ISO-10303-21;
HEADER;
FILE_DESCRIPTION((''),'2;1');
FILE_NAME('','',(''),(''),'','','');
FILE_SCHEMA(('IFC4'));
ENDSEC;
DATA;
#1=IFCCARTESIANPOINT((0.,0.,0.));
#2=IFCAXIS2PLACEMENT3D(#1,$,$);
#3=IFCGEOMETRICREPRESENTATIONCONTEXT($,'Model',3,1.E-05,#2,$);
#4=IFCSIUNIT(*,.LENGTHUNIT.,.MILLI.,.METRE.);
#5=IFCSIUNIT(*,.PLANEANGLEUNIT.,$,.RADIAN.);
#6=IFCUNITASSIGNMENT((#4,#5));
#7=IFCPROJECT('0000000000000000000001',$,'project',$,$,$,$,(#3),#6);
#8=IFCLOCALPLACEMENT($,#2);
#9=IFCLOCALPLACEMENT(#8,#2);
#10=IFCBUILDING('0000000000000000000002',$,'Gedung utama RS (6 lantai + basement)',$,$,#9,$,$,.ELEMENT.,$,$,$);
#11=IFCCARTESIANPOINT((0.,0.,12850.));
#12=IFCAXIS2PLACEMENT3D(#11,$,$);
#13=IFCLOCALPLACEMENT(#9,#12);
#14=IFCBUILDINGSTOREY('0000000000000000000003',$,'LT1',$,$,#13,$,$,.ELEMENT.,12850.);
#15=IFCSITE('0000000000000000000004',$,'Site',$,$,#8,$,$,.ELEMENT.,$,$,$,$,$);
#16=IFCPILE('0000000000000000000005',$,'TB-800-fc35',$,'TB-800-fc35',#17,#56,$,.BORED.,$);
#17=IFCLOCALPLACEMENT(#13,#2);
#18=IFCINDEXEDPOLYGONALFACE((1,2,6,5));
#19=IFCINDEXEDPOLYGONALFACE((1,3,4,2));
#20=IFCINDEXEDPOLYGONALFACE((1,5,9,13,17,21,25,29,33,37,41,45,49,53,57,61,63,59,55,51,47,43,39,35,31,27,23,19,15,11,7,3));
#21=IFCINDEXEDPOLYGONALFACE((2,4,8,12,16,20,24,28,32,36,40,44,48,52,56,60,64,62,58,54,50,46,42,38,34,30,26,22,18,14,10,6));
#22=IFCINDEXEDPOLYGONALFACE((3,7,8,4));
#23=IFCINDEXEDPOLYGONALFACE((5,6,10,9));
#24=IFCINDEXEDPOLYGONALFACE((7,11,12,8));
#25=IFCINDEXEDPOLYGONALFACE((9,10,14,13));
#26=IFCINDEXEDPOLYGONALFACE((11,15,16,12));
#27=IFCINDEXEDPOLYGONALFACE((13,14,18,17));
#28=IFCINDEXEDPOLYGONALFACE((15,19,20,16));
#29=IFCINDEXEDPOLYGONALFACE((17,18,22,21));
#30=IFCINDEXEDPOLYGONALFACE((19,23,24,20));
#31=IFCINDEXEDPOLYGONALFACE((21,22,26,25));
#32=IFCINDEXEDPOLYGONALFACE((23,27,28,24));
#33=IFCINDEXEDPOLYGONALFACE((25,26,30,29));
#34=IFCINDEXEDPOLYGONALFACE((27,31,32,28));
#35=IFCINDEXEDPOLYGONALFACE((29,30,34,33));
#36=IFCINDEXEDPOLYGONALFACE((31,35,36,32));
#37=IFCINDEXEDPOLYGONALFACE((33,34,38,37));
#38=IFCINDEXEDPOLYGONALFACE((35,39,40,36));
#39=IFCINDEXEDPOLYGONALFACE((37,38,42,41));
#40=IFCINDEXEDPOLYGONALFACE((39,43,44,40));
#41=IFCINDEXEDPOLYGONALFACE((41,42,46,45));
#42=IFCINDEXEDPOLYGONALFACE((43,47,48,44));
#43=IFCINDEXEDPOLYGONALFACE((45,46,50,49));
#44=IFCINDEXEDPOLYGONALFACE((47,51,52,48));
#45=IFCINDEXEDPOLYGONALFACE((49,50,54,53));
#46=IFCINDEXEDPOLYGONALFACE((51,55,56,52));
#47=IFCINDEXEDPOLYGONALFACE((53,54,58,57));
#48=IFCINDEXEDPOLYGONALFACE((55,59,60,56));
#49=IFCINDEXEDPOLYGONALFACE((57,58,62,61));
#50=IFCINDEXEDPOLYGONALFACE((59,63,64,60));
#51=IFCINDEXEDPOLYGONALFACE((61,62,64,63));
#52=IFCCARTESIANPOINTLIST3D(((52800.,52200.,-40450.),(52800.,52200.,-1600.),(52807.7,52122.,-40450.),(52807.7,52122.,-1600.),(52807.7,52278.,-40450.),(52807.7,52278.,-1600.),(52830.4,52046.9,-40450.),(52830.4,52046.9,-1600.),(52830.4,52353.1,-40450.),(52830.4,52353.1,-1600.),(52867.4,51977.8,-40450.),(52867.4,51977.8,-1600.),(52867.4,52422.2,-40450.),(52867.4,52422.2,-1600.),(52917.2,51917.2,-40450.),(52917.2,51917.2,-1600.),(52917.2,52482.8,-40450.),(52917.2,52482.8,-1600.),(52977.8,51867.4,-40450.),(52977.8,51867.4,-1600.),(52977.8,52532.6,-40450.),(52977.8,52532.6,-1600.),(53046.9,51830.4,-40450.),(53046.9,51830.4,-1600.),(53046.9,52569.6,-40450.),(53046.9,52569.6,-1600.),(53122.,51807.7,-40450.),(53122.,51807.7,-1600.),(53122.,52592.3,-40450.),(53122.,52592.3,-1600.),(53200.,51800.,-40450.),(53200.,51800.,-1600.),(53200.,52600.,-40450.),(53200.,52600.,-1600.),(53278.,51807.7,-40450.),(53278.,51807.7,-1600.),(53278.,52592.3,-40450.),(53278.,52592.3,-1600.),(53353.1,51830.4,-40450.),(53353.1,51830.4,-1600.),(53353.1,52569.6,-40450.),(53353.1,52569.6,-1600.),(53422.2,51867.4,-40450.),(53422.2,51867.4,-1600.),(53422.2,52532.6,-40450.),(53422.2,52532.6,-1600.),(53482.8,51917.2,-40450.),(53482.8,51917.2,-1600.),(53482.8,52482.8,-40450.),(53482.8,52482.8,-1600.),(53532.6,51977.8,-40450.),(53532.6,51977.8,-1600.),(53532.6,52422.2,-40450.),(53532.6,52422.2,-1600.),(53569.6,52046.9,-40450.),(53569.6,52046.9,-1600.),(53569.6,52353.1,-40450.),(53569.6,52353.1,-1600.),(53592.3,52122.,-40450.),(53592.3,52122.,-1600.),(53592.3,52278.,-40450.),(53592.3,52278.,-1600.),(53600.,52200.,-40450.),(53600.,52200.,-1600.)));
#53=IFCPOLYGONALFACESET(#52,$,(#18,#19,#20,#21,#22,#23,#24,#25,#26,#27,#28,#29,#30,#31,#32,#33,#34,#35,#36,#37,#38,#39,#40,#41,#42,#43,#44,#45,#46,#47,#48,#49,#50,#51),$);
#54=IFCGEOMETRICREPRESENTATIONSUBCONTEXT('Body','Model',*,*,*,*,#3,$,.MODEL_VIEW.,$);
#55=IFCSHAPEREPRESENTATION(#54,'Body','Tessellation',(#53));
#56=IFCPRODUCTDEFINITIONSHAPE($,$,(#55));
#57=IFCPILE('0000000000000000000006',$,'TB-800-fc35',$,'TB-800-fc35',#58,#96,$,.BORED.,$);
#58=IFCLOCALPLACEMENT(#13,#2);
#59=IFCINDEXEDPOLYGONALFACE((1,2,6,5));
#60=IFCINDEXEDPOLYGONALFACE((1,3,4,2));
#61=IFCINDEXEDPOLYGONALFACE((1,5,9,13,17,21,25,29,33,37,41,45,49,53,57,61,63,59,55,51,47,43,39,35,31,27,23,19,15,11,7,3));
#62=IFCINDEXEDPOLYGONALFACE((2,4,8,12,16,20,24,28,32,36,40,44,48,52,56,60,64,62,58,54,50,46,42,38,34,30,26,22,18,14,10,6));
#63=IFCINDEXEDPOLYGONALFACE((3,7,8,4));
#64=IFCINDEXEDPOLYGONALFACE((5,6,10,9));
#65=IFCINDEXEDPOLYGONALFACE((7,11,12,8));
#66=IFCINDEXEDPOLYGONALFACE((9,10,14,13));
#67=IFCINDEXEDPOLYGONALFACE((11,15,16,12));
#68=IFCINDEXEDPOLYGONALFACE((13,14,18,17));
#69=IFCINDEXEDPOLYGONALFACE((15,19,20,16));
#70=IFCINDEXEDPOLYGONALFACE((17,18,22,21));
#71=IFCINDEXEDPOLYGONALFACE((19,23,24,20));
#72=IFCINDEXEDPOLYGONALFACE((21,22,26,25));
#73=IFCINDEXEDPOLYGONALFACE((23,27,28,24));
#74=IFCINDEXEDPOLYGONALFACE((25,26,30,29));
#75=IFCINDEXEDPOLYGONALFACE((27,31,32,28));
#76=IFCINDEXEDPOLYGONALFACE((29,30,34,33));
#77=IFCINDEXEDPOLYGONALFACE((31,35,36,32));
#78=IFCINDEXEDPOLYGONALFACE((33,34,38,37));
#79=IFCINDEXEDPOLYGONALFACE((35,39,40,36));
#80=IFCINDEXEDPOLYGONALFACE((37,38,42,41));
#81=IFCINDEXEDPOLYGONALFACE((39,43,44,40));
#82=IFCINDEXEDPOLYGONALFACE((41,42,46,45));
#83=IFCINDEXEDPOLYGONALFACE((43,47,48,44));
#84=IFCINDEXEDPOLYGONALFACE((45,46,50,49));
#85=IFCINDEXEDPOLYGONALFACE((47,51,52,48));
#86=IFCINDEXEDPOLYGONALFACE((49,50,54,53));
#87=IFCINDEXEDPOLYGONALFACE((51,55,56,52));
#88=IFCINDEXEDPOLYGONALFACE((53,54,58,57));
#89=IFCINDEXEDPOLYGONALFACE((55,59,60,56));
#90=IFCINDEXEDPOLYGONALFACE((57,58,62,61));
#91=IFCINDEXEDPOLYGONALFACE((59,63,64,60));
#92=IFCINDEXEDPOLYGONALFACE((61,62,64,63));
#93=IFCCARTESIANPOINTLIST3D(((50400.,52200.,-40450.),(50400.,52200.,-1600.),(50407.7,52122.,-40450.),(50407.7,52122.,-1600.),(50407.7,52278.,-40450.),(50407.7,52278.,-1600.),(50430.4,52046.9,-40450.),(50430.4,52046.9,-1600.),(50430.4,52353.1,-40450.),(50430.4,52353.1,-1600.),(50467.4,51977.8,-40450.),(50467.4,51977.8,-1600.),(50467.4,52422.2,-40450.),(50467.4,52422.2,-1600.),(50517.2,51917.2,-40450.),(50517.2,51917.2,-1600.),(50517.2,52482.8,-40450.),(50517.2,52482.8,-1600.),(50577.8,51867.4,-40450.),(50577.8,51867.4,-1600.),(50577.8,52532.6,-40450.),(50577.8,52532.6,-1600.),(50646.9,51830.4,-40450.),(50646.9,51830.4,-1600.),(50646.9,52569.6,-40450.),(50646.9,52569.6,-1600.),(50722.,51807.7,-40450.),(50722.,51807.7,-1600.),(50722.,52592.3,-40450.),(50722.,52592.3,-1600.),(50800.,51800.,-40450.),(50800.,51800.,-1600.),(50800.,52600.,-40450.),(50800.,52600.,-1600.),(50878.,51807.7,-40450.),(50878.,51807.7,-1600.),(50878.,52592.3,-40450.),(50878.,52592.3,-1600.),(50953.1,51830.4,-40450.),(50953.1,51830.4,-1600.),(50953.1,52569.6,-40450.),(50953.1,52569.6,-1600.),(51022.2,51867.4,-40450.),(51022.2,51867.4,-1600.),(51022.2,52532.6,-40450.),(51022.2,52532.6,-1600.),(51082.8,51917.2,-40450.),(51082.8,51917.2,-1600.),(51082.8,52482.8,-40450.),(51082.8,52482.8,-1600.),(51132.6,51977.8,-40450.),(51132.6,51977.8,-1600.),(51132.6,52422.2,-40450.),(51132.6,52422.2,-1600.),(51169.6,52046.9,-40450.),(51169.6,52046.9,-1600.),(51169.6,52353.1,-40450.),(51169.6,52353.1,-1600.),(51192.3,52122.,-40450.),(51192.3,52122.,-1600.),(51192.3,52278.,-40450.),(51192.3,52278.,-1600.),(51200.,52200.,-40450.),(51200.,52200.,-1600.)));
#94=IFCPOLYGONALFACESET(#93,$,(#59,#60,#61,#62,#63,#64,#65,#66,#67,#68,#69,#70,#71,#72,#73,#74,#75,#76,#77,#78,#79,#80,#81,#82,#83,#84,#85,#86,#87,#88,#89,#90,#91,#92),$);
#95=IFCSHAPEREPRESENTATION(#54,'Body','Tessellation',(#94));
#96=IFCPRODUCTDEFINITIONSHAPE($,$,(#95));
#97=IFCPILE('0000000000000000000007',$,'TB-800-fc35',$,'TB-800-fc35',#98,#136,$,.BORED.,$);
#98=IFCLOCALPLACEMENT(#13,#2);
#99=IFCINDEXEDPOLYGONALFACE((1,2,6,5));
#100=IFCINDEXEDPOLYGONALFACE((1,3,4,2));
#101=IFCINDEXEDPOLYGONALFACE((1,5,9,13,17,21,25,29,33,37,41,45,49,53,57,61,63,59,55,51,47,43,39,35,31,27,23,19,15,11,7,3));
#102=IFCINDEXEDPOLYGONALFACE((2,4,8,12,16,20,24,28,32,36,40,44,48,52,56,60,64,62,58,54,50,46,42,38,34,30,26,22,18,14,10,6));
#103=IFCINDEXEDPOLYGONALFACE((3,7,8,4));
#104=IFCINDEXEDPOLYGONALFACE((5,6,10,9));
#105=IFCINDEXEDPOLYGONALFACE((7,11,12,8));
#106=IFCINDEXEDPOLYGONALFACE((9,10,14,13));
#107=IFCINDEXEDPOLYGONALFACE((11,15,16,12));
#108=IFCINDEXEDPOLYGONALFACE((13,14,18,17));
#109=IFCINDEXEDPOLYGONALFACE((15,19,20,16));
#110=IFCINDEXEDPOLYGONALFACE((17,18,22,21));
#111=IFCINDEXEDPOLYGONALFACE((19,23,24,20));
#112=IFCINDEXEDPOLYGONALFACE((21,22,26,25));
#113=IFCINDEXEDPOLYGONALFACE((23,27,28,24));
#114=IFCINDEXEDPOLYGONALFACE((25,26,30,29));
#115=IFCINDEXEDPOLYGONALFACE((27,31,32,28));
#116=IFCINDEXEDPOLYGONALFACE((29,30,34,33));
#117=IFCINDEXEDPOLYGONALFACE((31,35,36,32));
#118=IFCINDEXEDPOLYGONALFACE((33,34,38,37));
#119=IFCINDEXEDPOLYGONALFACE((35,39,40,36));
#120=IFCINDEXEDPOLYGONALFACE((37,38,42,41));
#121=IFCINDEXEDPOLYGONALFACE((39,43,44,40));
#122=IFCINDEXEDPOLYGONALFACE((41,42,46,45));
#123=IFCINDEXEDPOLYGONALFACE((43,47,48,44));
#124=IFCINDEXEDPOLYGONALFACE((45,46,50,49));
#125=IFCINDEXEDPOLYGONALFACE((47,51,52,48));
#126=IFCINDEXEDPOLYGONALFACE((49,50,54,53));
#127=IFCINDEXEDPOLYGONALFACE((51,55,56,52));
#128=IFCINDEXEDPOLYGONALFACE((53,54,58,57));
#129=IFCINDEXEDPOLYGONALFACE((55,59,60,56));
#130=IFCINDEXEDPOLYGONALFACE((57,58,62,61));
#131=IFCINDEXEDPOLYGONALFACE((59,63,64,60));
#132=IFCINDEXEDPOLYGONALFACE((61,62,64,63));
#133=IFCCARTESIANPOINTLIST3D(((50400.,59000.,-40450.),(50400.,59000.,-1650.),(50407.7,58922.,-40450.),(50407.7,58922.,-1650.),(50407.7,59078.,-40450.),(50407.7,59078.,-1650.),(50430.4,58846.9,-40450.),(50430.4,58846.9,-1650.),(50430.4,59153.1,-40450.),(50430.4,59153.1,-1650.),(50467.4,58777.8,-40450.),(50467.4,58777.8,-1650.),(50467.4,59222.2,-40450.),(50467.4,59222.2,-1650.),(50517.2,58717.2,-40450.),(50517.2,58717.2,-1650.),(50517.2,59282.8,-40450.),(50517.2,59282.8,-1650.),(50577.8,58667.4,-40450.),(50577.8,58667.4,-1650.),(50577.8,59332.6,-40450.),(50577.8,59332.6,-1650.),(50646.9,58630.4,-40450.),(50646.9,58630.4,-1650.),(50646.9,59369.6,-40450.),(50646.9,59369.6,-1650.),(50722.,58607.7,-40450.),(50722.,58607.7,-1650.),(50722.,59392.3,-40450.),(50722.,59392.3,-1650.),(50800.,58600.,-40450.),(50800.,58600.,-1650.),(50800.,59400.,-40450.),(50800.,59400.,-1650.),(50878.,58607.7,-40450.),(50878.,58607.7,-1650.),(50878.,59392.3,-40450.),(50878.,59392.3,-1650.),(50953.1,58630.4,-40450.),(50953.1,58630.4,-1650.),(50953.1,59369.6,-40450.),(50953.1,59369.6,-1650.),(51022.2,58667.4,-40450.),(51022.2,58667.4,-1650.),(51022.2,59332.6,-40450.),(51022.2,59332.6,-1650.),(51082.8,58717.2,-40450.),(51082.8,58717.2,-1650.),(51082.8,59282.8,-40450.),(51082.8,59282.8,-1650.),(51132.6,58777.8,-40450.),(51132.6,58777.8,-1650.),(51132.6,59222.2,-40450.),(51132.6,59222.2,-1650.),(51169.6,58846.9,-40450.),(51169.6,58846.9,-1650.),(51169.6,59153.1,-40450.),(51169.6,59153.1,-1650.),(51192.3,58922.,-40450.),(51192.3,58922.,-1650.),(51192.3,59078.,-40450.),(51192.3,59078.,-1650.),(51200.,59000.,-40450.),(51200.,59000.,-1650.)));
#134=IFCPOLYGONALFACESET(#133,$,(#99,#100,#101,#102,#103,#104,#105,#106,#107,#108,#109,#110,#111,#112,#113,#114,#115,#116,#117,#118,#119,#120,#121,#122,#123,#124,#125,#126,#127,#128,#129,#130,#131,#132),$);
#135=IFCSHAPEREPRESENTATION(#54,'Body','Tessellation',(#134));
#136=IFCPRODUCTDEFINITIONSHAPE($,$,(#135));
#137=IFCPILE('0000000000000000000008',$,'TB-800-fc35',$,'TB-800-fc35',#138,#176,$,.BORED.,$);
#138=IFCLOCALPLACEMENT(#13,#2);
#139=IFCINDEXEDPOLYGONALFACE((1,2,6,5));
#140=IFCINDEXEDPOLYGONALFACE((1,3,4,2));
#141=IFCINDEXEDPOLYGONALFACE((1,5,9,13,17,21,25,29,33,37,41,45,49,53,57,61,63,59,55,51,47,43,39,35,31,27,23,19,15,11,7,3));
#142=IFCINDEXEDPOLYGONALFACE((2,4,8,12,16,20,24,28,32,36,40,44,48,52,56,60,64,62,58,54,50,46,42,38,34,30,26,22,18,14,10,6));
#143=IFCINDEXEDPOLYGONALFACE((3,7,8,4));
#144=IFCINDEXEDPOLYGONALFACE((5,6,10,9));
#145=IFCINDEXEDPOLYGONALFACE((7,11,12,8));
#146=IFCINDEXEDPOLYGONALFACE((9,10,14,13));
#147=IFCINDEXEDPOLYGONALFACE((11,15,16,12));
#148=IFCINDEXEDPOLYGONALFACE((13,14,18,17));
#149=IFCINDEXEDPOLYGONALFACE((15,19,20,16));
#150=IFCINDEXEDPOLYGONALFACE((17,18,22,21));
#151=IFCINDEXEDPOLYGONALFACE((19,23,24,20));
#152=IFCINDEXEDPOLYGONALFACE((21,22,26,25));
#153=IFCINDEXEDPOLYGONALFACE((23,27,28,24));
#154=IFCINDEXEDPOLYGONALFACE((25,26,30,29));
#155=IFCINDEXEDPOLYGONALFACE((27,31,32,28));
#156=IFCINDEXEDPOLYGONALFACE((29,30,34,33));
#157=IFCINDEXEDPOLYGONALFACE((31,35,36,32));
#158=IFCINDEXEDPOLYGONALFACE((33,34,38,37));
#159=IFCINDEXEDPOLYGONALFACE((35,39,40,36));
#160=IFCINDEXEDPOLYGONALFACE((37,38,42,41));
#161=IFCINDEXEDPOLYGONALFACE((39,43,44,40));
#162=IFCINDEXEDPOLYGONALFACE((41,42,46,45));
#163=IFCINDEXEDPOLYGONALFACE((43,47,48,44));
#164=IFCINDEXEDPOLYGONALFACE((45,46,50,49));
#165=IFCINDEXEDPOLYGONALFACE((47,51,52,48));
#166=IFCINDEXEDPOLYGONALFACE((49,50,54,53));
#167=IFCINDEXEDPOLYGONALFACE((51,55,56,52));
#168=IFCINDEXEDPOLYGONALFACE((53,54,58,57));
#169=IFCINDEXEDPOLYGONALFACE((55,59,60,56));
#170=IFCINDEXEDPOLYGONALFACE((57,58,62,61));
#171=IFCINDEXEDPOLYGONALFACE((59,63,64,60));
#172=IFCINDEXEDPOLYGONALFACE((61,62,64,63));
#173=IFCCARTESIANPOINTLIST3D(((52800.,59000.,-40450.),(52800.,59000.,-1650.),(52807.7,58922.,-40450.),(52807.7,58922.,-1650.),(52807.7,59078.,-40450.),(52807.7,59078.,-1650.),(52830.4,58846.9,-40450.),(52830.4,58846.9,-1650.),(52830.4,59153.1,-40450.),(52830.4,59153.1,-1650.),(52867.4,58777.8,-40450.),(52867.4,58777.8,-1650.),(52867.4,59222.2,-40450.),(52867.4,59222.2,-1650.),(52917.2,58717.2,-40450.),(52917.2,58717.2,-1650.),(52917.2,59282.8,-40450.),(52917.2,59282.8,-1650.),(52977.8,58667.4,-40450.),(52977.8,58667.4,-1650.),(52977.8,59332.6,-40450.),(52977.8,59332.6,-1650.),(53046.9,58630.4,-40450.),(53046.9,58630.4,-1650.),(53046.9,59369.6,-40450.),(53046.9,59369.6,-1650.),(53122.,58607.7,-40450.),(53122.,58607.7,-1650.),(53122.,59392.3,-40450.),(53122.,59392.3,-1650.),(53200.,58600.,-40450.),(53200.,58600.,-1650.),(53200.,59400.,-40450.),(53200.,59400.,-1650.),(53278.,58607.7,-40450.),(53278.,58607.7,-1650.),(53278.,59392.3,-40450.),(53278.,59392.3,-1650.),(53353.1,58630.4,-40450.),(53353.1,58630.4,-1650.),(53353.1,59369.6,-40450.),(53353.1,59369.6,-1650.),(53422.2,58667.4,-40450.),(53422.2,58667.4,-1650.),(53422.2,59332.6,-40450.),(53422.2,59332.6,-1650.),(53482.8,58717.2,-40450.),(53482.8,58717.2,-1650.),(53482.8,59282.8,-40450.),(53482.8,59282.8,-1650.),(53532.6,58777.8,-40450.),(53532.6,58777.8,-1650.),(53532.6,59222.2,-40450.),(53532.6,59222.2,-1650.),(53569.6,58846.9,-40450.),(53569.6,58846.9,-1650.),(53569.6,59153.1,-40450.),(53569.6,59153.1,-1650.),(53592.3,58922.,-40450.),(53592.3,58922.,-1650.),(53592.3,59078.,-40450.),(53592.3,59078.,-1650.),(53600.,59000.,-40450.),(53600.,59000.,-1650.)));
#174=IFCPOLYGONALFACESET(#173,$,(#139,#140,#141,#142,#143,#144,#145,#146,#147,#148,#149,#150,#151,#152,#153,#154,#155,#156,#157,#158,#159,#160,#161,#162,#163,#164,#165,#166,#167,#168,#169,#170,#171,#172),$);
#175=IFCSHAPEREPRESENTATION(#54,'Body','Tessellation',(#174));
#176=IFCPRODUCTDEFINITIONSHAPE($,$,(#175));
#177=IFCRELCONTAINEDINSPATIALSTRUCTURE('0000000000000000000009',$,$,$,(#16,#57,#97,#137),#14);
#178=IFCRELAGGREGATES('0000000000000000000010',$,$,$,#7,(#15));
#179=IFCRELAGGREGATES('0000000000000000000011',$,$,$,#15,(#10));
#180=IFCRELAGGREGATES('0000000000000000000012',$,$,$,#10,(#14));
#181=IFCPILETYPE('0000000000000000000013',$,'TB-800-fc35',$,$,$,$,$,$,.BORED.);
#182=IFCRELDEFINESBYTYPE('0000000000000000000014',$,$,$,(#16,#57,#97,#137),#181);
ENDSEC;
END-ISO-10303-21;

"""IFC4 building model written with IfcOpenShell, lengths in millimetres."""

from ifc_helpers import new_model, si_unit, frame, origin, origin_2d, place, context, subcontext, project, spatial, circle, extrude, material_profile, profile_set, profile_usage, type_object, element, save


model = new_model("IFC4")

# Units and contexts
model_context = context("Model", 3, precision=1e-05, world=origin())
body_context = subcontext(model_context, "Body", "Model", "MODEL_VIEW")
ifc_project = project(units=[si_unit("LENGTHUNIT", "METRE", prefix="MILLI"), si_unit("PLANEANGLEUNIT", "RADIAN")], contexts=[model_context])

# Site, building, storey
site_placement = place(None, origin())
site = spatial("IfcSite", under=ifc_project, at=site_placement, Name="Site", CompositionType="ELEMENT")
building_placement = place(site_placement, origin())
building = spatial("IfcBuilding", under=site, at=building_placement, Name="Gedung utama RS (6 lantai + basement)", CompositionType="ELEMENT")
storey_placement = place(building_placement, frame((0.0, 0.0, 12850.0)))
storey = spatial("IfcBuildingStorey", under=building, at=storey_placement, Name="LT1", CompositionType="ELEMENT", Elevation=12850.0)

# Piles
ifc_material_profile = material_profile(None, circle(Radius=400.0, at=origin_2d()), Name="TB-800-fc35")
ifc_profile_set = profile_set([ifc_material_profile], Name="TB-800-fc35")
ifc_profile_usage = profile_usage(ifc_profile_set, cardinal=5)
pile_type = type_object("IfcPileType", Name="TB-800-fc35", PredefinedType="BORED")
for number, where, z_axis, x_axis, name in (
    (1, (53200.0, 52200.0, -40450.0), (0.0, 0.0, 1.0), (1.0, 0.0, 0.0), "TB-800-fc35"),
    (2, (50800.0, 52200.0, -40450.0), (0.0, 0.0, 1.0), (1.0, 0.0, 0.0), "TB-800-fc35"),
):
    element("IfcPile", number, at=place(storey_placement, frame(where, z_axis=z_axis, x_axis=x_axis)), inside=storey, type_object=pile_type, material=ifc_profile_usage, Name=name, ObjectType="TB-800-fc35", PredefinedType="BORED", context=body_context, shape_type="SweptSolid", body=[
        extrude(circle(Radius=400.0, at=origin_2d()), origin(), (0.0, 0.0, 1.0), 38850.0),
    ])
for number, where, z_axis, x_axis, name in (
    (3, (50800.0, 59000.0, -40450.0), (0.0, 0.0, 1.0), (1.0, 0.0, 0.0), "TB-800-fc35"),
    (4, (53200.0, 59000.0, -40450.0), (0.0, 0.0, 1.0), (1.0, 0.0, 0.0), "TB-800-fc35"),
):
    element("IfcPile", number, at=place(storey_placement, frame(where, z_axis=z_axis, x_axis=x_axis)), inside=storey, type_object=pile_type, material=ifc_profile_usage, Name=name, ObjectType="TB-800-fc35", PredefinedType="BORED", context=body_context, shape_type="SweptSolid", body=[
        extrude(circle(Radius=400.0, at=origin_2d()), origin(), (0.0, 0.0, 1.0), 38800.0),
    ])

save(model, "model.ifc")
